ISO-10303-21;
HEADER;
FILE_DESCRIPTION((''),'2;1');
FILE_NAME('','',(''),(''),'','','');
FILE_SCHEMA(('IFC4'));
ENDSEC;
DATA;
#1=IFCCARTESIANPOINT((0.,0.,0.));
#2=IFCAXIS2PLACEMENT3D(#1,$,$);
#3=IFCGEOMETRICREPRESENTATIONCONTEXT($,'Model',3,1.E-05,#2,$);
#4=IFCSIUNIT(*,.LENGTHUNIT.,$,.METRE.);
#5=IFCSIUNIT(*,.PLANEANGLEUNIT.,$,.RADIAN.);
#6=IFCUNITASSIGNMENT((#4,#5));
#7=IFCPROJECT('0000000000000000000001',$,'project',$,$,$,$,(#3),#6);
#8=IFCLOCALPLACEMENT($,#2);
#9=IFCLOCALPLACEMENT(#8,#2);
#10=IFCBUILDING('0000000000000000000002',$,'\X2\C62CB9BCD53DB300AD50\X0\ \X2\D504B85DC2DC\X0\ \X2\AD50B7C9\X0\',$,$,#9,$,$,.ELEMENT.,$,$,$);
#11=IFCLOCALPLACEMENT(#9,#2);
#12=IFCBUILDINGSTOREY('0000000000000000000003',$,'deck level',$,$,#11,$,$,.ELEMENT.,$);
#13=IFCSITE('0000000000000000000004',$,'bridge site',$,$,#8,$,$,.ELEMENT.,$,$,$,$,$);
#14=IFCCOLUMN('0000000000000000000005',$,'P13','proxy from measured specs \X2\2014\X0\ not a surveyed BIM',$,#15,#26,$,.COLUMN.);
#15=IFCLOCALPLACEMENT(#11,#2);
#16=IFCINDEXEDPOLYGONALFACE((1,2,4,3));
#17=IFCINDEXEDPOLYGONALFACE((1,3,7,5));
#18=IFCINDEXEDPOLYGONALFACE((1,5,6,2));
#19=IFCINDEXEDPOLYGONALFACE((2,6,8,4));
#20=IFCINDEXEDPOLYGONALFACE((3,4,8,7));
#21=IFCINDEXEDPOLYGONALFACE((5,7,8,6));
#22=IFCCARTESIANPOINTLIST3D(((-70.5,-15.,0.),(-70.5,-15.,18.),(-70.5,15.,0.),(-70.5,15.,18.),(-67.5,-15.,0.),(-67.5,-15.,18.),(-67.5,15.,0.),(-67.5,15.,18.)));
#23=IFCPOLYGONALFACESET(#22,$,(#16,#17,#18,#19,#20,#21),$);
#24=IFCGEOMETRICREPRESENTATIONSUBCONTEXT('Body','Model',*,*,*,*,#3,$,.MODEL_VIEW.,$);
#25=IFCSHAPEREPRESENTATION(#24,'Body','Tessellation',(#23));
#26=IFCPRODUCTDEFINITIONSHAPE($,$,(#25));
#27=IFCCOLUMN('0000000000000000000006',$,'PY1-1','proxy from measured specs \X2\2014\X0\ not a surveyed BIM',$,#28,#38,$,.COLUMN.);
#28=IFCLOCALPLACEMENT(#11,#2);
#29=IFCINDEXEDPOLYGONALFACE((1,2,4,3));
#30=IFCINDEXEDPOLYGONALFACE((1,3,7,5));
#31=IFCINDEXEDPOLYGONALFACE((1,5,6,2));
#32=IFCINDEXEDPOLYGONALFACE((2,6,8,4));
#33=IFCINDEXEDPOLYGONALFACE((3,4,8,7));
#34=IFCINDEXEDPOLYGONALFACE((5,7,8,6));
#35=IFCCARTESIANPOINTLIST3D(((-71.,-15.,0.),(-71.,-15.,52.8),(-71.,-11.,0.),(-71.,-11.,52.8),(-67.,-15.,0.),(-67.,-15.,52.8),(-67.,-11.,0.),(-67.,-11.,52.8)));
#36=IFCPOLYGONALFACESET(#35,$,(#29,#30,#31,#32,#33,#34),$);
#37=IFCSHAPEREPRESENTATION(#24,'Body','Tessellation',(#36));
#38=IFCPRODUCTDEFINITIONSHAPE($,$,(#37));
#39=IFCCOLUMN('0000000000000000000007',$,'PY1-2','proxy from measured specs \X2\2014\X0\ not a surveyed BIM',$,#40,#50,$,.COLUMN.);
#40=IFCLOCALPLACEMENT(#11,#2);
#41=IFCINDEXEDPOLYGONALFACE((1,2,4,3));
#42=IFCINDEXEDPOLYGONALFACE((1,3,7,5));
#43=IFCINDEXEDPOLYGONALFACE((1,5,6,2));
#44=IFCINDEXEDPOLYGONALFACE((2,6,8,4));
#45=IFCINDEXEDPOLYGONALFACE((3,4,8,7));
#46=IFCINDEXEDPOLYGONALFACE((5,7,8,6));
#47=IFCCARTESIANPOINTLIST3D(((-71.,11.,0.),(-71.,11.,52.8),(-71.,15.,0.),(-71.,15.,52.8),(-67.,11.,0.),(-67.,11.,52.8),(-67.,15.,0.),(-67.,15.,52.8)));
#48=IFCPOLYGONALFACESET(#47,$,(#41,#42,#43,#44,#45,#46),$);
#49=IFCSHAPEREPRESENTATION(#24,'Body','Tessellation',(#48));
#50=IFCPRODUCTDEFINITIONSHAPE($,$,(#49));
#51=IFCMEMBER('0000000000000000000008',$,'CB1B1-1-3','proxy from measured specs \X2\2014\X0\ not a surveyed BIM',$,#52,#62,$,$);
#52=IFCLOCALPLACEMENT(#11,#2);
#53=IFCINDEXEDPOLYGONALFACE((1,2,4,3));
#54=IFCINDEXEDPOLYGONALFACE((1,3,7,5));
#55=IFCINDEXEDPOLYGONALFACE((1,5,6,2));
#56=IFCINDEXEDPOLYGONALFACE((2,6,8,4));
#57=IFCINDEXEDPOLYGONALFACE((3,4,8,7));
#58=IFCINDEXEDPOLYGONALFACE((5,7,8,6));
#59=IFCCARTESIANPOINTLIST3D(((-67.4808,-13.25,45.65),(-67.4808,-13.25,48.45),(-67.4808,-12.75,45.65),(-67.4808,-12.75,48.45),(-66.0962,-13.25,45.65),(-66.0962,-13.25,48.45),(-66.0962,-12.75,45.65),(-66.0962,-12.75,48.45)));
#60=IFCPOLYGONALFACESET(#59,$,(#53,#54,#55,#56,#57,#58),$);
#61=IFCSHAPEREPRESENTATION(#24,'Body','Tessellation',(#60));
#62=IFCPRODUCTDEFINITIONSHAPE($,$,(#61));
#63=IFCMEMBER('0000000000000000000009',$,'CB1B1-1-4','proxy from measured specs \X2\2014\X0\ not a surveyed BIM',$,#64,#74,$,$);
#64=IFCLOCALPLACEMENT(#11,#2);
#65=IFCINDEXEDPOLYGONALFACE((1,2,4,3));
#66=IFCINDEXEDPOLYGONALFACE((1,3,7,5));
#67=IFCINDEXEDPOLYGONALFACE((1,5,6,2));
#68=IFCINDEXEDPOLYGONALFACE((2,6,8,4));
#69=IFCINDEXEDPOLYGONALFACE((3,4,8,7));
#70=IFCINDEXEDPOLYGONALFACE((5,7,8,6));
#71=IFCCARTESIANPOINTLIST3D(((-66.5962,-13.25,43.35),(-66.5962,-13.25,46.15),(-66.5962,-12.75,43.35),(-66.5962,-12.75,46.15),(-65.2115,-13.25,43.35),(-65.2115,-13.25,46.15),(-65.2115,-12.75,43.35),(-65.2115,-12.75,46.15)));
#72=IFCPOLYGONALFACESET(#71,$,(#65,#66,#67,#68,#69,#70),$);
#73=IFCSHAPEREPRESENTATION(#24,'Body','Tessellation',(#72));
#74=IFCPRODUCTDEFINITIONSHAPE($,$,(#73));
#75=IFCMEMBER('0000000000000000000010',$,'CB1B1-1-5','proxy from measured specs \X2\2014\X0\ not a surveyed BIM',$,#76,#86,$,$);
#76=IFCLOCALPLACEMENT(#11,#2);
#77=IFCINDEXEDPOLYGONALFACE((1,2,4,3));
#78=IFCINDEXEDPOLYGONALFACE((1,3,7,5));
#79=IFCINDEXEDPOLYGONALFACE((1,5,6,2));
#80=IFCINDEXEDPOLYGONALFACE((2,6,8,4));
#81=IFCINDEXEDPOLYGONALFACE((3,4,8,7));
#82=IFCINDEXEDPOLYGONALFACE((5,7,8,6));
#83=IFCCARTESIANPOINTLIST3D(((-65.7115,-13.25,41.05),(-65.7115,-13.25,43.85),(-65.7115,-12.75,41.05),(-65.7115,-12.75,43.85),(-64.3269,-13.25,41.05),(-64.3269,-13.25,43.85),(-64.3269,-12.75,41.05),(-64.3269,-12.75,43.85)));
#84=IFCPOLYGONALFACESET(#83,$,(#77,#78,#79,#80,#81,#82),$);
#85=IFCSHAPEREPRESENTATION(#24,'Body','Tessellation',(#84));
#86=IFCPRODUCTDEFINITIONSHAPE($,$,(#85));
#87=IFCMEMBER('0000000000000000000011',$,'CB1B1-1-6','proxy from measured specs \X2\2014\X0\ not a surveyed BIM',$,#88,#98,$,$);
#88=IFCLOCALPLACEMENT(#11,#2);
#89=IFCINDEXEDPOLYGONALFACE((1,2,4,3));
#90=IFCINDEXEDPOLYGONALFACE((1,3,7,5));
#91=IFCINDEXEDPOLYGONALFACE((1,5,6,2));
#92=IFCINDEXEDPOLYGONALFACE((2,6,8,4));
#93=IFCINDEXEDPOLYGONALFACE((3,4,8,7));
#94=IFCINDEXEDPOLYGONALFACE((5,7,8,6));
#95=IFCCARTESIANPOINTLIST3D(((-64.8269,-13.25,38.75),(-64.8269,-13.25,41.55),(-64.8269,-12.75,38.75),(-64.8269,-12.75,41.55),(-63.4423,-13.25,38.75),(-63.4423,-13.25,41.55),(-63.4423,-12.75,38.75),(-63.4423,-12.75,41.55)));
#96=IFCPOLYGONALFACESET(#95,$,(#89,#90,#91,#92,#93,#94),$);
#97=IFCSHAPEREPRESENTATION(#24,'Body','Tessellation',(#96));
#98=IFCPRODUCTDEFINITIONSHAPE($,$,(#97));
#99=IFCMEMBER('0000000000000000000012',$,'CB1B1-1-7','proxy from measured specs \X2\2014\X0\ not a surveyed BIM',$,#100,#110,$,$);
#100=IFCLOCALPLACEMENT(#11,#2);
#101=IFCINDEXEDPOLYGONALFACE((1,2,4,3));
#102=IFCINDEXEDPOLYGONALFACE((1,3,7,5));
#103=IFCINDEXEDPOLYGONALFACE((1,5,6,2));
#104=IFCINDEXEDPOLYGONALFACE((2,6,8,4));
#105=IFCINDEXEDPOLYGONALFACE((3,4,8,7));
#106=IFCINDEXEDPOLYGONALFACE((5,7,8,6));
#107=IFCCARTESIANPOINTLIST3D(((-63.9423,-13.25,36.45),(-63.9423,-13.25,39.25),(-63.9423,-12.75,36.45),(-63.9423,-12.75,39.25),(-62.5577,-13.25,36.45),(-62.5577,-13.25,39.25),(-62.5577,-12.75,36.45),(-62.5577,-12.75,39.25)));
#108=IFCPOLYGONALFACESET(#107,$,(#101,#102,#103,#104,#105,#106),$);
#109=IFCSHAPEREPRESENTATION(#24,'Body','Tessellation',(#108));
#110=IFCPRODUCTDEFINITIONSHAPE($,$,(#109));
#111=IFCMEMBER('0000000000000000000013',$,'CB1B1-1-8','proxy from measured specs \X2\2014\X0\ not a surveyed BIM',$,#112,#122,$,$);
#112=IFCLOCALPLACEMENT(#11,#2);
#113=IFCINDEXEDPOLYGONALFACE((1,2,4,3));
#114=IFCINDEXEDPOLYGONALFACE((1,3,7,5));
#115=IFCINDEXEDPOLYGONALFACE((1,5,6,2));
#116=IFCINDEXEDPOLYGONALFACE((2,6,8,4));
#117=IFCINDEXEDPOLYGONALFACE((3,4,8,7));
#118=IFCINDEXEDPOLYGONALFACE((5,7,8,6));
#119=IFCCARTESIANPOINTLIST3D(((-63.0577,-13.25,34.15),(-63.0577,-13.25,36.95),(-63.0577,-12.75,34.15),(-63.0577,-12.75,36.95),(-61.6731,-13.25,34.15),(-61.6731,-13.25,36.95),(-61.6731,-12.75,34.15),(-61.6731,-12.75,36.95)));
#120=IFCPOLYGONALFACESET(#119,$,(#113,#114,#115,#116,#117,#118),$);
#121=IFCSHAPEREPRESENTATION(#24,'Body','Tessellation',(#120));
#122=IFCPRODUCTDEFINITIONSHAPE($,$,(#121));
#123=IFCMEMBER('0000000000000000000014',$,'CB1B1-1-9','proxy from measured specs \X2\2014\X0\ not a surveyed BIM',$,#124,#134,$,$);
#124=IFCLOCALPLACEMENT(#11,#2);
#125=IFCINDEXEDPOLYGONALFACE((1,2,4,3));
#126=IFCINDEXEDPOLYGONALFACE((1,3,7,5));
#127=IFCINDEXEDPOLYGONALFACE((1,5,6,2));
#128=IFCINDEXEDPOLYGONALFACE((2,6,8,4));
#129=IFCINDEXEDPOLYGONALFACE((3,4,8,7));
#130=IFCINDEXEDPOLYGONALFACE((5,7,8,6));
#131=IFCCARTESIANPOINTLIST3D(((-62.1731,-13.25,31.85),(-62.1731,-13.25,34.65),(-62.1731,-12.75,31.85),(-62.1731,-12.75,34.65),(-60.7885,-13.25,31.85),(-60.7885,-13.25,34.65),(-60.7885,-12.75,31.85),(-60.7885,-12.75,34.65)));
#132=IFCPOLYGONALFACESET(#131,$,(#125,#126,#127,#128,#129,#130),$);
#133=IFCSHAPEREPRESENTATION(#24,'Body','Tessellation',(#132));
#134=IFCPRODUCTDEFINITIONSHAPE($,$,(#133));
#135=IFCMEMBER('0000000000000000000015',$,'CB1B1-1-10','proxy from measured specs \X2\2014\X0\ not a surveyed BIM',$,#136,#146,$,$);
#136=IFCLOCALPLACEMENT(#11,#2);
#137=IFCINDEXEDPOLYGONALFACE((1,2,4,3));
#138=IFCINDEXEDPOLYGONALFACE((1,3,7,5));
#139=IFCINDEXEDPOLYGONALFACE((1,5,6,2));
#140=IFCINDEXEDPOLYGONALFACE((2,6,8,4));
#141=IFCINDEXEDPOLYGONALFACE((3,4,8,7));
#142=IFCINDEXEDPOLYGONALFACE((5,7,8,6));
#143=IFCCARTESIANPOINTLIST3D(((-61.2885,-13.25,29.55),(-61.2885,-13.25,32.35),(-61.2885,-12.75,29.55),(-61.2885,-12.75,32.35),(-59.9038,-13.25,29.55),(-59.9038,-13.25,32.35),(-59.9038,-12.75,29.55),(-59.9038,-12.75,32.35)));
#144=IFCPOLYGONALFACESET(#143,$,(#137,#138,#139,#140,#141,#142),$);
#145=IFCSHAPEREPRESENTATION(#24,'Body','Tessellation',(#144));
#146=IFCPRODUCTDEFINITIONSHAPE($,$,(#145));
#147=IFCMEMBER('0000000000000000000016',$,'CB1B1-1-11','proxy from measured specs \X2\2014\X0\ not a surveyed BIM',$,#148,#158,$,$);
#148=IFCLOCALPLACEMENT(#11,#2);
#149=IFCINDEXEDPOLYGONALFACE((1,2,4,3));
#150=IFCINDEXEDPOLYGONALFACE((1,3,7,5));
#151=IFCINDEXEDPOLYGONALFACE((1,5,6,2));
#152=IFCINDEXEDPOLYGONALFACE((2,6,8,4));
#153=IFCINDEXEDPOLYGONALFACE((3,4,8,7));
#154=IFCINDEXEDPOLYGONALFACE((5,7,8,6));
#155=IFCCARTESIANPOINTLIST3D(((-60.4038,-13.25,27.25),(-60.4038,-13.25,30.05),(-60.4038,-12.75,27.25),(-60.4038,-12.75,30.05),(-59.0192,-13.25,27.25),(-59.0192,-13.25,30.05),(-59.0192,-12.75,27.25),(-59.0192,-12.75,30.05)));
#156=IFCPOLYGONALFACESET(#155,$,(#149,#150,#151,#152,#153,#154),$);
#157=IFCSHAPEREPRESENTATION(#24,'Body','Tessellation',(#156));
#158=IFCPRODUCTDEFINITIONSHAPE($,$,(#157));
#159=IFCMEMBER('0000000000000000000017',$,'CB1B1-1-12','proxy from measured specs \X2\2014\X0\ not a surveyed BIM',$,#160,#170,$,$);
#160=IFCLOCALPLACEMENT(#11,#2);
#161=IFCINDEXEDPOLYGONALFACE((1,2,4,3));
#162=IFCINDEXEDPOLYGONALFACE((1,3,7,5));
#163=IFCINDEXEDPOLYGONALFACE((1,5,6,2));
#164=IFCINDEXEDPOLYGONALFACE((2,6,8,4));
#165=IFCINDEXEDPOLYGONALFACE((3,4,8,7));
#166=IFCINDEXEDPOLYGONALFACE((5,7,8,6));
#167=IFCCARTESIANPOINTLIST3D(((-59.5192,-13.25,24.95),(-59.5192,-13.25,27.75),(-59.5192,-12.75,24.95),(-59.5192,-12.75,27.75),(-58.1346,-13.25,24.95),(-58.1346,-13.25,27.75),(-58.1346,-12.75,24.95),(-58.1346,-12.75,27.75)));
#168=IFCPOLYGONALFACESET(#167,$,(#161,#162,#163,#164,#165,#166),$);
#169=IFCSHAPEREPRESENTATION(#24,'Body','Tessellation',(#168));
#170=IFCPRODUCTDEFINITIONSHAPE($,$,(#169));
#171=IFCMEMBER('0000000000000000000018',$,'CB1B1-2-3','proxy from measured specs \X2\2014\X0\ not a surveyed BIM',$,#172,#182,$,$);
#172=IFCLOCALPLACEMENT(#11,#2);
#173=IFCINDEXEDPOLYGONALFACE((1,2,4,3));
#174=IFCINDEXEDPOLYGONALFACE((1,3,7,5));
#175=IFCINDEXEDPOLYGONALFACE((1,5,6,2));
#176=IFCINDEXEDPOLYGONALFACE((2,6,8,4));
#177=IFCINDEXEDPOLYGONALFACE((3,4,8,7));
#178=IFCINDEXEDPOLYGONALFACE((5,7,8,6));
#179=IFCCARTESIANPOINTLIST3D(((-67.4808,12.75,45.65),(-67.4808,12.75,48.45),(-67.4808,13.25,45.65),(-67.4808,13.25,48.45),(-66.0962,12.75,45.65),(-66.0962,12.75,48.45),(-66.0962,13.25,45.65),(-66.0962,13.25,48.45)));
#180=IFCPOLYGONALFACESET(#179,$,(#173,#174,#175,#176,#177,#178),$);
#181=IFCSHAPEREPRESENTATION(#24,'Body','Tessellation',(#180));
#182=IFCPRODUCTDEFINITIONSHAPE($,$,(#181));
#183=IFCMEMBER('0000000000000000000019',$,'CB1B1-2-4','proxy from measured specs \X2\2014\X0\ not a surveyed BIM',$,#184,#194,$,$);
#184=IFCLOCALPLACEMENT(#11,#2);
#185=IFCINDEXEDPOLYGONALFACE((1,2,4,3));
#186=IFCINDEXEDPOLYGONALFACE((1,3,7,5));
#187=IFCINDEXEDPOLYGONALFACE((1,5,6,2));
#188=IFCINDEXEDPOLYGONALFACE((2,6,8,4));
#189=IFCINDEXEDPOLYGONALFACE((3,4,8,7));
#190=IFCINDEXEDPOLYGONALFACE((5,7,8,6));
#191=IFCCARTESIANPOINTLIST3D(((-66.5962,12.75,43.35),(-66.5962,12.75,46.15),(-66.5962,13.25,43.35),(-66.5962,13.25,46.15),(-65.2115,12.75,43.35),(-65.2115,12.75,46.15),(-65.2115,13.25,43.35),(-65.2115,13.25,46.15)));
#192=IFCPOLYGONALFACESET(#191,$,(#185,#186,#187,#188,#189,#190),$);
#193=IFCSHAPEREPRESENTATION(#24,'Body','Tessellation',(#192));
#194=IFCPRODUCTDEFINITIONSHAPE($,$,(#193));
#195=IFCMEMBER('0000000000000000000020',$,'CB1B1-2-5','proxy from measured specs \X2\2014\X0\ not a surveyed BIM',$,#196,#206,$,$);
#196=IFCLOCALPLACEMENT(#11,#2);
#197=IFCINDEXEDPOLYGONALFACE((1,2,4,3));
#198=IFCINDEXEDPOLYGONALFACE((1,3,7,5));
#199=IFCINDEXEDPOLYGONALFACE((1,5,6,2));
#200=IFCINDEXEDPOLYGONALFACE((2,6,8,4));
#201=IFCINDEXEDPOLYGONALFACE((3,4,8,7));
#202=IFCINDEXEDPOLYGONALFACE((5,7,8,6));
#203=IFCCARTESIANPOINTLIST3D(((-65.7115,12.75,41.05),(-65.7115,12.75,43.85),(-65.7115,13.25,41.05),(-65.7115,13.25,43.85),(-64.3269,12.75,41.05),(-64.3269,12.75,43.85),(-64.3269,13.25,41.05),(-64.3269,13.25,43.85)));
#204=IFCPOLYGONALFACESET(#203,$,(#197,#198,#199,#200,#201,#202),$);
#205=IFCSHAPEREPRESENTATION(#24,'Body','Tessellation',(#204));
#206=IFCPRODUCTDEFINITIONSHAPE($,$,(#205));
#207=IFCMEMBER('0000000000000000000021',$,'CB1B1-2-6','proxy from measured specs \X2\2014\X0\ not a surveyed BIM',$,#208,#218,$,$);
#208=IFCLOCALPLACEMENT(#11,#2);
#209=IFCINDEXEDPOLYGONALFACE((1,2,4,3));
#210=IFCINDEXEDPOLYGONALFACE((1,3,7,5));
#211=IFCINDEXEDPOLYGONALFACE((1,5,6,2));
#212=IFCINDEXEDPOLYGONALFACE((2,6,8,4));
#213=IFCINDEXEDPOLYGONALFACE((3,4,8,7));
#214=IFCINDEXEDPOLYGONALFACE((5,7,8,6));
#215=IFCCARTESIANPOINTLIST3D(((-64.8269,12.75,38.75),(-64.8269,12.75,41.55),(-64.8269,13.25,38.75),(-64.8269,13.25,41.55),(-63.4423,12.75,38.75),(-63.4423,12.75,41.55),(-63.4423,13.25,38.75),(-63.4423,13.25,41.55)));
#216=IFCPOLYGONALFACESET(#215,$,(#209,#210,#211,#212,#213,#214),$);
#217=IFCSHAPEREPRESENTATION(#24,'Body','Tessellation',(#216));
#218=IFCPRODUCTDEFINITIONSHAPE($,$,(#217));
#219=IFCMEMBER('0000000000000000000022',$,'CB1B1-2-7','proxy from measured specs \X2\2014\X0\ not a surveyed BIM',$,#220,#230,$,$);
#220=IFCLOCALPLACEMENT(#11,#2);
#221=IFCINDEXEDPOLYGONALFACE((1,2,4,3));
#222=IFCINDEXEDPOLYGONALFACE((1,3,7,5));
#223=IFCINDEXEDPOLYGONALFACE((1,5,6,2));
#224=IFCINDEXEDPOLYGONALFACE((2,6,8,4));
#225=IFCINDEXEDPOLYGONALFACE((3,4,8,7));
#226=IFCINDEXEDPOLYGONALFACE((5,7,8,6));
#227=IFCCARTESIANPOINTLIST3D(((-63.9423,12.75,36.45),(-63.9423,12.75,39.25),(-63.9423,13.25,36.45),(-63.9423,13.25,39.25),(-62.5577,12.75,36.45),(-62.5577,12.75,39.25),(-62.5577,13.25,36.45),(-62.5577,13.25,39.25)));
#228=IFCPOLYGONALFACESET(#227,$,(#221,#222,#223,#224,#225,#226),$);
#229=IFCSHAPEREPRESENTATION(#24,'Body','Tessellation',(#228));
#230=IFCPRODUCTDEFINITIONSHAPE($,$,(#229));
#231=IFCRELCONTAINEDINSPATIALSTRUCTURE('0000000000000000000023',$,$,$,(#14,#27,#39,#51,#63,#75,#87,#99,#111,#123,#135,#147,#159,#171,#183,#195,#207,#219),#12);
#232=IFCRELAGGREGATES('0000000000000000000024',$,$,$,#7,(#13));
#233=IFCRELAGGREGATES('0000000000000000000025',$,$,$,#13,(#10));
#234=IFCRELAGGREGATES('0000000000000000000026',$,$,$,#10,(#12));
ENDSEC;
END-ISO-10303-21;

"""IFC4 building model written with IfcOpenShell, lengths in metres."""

from ifc_helpers import new_model, si_unit, frame, origin, origin_2d, place, context, subcontext, project, spatial, rectangle, extrude, element, save


model = new_model("IFC4")

# Units and contexts
model_context = context("Model", 3, precision=1e-05, world=origin())
body_context = subcontext(model_context, "Body", "Model", "MODEL_VIEW")
ifc_project = project(units=[si_unit("LENGTHUNIT", "METRE"), si_unit("PLANEANGLEUNIT", "RADIAN")], contexts=[model_context])

# Site, building, storey
site_placement = place(None, origin())
site = spatial("IfcSite", under=ifc_project, at=site_placement, Name="bridge site", CompositionType="ELEMENT")
building_placement = place(site_placement, origin())
building = spatial("IfcBuilding", under=site, at=building_placement, Name="올림픽대교 프록시 교량", CompositionType="ELEMENT")
storey_placement = place(building_placement, origin())
storey = spatial("IfcBuildingStorey", under=building, at=storey_placement, Name="deck level", CompositionType="ELEMENT")

# Columns
column_placement = place(storey_placement, frame((-69.0, 0.0, 0.0)))
element("IfcColumn", 1, at=column_placement, inside=storey, Name="P13", Description="proxy from measured specs — not a surveyed BIM", PredefinedType="COLUMN", context=body_context, shape_type="SweptSolid", body=[
    extrude(rectangle(XDim=3.0, YDim=30.0, at=origin_2d()), origin(), (0.0, 0.0, 1.0), 18.0),
])
for number, where, name in (
    (2, (-69.0, -13.0, 0.0), "PY1-1"),
    (3, (-69.0, 13.0, 0.0), "PY1-2"),
):
    element("IfcColumn", number, at=place(storey_placement, frame(where)), inside=storey, Name=name, Description="proxy from measured specs — not a surveyed BIM", PredefinedType="COLUMN", context=body_context, shape_type="SweptSolid", body=[
        extrude(rectangle(XDim=4.0, YDim=4.0, at=origin_2d()), origin(), (0.0, 0.0, 1.0), 52.8),
    ])

# Members
member_1_placement = place(storey_placement, frame((-66.7885, -13.0, 45.65)))
element("IfcMember", 4, at=member_1_placement, inside=storey, Name="CB1B1-1-3", Description="proxy from measured specs — not a surveyed BIM", context=body_context, shape_type="SweptSolid", body=[
    extrude(rectangle(XDim=1.3846, YDim=0.5, at=origin_2d()), origin(), (0.0, 0.0, 1.0), 2.8),
])
member_2_placement = place(storey_placement, frame((-65.9038, -13.0, 43.35)))
element("IfcMember", 5, at=member_2_placement, inside=storey, Name="CB1B1-1-4", Description="proxy from measured specs — not a surveyed BIM", context=body_context, shape_type="SweptSolid", body=[
    extrude(rectangle(XDim=1.3846, YDim=0.5, at=origin_2d()), origin(), (0.0, 0.0, 1.0), 2.8),
])
for number, where, name in (
    (6, (-65.0192, -13.0, 41.05), "CB1B1-1-5"),
    (7, (-64.1346, -13.0, 38.75), "CB1B1-1-6"),
    (8, (-63.25, -13.0, 36.45), "CB1B1-1-7"),
):
    element("IfcMember", number, at=place(storey_placement, frame(where)), inside=storey, Name=name, Description="proxy from measured specs — not a surveyed BIM", context=body_context, shape_type="SweptSolid", body=[
        extrude(rectangle(XDim=1.3846, YDim=0.5, at=origin_2d()), origin(), (0.0, 0.0, 1.0), 2.8),
    ])
member_3_placement = place(storey_placement, frame((-62.3654, -13.0, 34.15)))
element("IfcMember", 9, at=member_3_placement, inside=storey, Name="CB1B1-1-8", Description="proxy from measured specs — not a surveyed BIM", context=body_context, shape_type="SweptSolid", body=[
    extrude(rectangle(XDim=1.3846, YDim=0.5, at=origin_2d()), origin(), (0.0, 0.0, 1.0), 2.8),
])
member_4_placement = place(storey_placement, frame((-61.4808, -13.0, 31.85)))
element("IfcMember", 10, at=member_4_placement, inside=storey, Name="CB1B1-1-9", Description="proxy from measured specs — not a surveyed BIM", context=body_context, shape_type="SweptSolid", body=[
    extrude(rectangle(XDim=1.3846, YDim=0.5, at=origin_2d()), origin(), (0.0, 0.0, 1.0), 2.8),
])
member_5_placement = place(storey_placement, frame((-60.5962, -13.0, 29.55)))
element("IfcMember", 11, at=member_5_placement, inside=storey, Name="CB1B1-1-10", Description="proxy from measured specs — not a surveyed BIM", context=body_context, shape_type="SweptSolid", body=[
    extrude(rectangle(XDim=1.3846, YDim=0.5, at=origin_2d()), origin(), (0.0, 0.0, 1.0), 2.8),
])
member_6_placement = place(storey_placement, frame((-59.7115, -13.0, 27.25)))
element("IfcMember", 12, at=member_6_placement, inside=storey, Name="CB1B1-1-11", Description="proxy from measured specs — not a surveyed BIM", context=body_context, shape_type="SweptSolid", body=[
    extrude(rectangle(XDim=1.3846, YDim=0.5, at=origin_2d()), origin(), (0.0, 0.0, 1.0), 2.8),
])
member_7_placement = place(storey_placement, frame((-58.8269, -13.0, 24.95)))
element("IfcMember", 13, at=member_7_placement, inside=storey, Name="CB1B1-1-12", Description="proxy from measured specs — not a surveyed BIM", context=body_context, shape_type="SweptSolid", body=[
    extrude(rectangle(XDim=1.3846, YDim=0.5, at=origin_2d()), origin(), (0.0, 0.0, 1.0), 2.8),
])
member_8_placement = place(storey_placement, frame((-66.7885, 13.0, 45.65)))
element("IfcMember", 14, at=member_8_placement, inside=storey, Name="CB1B1-2-3", Description="proxy from measured specs — not a surveyed BIM", context=body_context, shape_type="SweptSolid", body=[
    extrude(rectangle(XDim=1.3846, YDim=0.5, at=origin_2d()), origin(), (0.0, 0.0, 1.0), 2.8),
])
member_9_placement = place(storey_placement, frame((-65.9038, 13.0, 43.35)))
element("IfcMember", 15, at=member_9_placement, inside=storey, Name="CB1B1-2-4", Description="proxy from measured specs — not a surveyed BIM", context=body_context, shape_type="SweptSolid", body=[
    extrude(rectangle(XDim=1.3846, YDim=0.5, at=origin_2d()), origin(), (0.0, 0.0, 1.0), 2.8),
])
for number, where, name in (
    (16, (-65.0192, 13.0, 41.05), "CB1B1-2-5"),
    (17, (-64.1346, 13.0, 38.75), "CB1B1-2-6"),
    (18, (-63.25, 13.0, 36.45), "CB1B1-2-7"),
):
    element("IfcMember", number, at=place(storey_placement, frame(where)), inside=storey, Name=name, Description="proxy from measured specs — not a surveyed BIM", context=body_context, shape_type="SweptSolid", body=[
        extrude(rectangle(XDim=1.3846, YDim=0.5, at=origin_2d()), origin(), (0.0, 0.0, 1.0), 2.8),
    ])

save(model, "model.ifc")
